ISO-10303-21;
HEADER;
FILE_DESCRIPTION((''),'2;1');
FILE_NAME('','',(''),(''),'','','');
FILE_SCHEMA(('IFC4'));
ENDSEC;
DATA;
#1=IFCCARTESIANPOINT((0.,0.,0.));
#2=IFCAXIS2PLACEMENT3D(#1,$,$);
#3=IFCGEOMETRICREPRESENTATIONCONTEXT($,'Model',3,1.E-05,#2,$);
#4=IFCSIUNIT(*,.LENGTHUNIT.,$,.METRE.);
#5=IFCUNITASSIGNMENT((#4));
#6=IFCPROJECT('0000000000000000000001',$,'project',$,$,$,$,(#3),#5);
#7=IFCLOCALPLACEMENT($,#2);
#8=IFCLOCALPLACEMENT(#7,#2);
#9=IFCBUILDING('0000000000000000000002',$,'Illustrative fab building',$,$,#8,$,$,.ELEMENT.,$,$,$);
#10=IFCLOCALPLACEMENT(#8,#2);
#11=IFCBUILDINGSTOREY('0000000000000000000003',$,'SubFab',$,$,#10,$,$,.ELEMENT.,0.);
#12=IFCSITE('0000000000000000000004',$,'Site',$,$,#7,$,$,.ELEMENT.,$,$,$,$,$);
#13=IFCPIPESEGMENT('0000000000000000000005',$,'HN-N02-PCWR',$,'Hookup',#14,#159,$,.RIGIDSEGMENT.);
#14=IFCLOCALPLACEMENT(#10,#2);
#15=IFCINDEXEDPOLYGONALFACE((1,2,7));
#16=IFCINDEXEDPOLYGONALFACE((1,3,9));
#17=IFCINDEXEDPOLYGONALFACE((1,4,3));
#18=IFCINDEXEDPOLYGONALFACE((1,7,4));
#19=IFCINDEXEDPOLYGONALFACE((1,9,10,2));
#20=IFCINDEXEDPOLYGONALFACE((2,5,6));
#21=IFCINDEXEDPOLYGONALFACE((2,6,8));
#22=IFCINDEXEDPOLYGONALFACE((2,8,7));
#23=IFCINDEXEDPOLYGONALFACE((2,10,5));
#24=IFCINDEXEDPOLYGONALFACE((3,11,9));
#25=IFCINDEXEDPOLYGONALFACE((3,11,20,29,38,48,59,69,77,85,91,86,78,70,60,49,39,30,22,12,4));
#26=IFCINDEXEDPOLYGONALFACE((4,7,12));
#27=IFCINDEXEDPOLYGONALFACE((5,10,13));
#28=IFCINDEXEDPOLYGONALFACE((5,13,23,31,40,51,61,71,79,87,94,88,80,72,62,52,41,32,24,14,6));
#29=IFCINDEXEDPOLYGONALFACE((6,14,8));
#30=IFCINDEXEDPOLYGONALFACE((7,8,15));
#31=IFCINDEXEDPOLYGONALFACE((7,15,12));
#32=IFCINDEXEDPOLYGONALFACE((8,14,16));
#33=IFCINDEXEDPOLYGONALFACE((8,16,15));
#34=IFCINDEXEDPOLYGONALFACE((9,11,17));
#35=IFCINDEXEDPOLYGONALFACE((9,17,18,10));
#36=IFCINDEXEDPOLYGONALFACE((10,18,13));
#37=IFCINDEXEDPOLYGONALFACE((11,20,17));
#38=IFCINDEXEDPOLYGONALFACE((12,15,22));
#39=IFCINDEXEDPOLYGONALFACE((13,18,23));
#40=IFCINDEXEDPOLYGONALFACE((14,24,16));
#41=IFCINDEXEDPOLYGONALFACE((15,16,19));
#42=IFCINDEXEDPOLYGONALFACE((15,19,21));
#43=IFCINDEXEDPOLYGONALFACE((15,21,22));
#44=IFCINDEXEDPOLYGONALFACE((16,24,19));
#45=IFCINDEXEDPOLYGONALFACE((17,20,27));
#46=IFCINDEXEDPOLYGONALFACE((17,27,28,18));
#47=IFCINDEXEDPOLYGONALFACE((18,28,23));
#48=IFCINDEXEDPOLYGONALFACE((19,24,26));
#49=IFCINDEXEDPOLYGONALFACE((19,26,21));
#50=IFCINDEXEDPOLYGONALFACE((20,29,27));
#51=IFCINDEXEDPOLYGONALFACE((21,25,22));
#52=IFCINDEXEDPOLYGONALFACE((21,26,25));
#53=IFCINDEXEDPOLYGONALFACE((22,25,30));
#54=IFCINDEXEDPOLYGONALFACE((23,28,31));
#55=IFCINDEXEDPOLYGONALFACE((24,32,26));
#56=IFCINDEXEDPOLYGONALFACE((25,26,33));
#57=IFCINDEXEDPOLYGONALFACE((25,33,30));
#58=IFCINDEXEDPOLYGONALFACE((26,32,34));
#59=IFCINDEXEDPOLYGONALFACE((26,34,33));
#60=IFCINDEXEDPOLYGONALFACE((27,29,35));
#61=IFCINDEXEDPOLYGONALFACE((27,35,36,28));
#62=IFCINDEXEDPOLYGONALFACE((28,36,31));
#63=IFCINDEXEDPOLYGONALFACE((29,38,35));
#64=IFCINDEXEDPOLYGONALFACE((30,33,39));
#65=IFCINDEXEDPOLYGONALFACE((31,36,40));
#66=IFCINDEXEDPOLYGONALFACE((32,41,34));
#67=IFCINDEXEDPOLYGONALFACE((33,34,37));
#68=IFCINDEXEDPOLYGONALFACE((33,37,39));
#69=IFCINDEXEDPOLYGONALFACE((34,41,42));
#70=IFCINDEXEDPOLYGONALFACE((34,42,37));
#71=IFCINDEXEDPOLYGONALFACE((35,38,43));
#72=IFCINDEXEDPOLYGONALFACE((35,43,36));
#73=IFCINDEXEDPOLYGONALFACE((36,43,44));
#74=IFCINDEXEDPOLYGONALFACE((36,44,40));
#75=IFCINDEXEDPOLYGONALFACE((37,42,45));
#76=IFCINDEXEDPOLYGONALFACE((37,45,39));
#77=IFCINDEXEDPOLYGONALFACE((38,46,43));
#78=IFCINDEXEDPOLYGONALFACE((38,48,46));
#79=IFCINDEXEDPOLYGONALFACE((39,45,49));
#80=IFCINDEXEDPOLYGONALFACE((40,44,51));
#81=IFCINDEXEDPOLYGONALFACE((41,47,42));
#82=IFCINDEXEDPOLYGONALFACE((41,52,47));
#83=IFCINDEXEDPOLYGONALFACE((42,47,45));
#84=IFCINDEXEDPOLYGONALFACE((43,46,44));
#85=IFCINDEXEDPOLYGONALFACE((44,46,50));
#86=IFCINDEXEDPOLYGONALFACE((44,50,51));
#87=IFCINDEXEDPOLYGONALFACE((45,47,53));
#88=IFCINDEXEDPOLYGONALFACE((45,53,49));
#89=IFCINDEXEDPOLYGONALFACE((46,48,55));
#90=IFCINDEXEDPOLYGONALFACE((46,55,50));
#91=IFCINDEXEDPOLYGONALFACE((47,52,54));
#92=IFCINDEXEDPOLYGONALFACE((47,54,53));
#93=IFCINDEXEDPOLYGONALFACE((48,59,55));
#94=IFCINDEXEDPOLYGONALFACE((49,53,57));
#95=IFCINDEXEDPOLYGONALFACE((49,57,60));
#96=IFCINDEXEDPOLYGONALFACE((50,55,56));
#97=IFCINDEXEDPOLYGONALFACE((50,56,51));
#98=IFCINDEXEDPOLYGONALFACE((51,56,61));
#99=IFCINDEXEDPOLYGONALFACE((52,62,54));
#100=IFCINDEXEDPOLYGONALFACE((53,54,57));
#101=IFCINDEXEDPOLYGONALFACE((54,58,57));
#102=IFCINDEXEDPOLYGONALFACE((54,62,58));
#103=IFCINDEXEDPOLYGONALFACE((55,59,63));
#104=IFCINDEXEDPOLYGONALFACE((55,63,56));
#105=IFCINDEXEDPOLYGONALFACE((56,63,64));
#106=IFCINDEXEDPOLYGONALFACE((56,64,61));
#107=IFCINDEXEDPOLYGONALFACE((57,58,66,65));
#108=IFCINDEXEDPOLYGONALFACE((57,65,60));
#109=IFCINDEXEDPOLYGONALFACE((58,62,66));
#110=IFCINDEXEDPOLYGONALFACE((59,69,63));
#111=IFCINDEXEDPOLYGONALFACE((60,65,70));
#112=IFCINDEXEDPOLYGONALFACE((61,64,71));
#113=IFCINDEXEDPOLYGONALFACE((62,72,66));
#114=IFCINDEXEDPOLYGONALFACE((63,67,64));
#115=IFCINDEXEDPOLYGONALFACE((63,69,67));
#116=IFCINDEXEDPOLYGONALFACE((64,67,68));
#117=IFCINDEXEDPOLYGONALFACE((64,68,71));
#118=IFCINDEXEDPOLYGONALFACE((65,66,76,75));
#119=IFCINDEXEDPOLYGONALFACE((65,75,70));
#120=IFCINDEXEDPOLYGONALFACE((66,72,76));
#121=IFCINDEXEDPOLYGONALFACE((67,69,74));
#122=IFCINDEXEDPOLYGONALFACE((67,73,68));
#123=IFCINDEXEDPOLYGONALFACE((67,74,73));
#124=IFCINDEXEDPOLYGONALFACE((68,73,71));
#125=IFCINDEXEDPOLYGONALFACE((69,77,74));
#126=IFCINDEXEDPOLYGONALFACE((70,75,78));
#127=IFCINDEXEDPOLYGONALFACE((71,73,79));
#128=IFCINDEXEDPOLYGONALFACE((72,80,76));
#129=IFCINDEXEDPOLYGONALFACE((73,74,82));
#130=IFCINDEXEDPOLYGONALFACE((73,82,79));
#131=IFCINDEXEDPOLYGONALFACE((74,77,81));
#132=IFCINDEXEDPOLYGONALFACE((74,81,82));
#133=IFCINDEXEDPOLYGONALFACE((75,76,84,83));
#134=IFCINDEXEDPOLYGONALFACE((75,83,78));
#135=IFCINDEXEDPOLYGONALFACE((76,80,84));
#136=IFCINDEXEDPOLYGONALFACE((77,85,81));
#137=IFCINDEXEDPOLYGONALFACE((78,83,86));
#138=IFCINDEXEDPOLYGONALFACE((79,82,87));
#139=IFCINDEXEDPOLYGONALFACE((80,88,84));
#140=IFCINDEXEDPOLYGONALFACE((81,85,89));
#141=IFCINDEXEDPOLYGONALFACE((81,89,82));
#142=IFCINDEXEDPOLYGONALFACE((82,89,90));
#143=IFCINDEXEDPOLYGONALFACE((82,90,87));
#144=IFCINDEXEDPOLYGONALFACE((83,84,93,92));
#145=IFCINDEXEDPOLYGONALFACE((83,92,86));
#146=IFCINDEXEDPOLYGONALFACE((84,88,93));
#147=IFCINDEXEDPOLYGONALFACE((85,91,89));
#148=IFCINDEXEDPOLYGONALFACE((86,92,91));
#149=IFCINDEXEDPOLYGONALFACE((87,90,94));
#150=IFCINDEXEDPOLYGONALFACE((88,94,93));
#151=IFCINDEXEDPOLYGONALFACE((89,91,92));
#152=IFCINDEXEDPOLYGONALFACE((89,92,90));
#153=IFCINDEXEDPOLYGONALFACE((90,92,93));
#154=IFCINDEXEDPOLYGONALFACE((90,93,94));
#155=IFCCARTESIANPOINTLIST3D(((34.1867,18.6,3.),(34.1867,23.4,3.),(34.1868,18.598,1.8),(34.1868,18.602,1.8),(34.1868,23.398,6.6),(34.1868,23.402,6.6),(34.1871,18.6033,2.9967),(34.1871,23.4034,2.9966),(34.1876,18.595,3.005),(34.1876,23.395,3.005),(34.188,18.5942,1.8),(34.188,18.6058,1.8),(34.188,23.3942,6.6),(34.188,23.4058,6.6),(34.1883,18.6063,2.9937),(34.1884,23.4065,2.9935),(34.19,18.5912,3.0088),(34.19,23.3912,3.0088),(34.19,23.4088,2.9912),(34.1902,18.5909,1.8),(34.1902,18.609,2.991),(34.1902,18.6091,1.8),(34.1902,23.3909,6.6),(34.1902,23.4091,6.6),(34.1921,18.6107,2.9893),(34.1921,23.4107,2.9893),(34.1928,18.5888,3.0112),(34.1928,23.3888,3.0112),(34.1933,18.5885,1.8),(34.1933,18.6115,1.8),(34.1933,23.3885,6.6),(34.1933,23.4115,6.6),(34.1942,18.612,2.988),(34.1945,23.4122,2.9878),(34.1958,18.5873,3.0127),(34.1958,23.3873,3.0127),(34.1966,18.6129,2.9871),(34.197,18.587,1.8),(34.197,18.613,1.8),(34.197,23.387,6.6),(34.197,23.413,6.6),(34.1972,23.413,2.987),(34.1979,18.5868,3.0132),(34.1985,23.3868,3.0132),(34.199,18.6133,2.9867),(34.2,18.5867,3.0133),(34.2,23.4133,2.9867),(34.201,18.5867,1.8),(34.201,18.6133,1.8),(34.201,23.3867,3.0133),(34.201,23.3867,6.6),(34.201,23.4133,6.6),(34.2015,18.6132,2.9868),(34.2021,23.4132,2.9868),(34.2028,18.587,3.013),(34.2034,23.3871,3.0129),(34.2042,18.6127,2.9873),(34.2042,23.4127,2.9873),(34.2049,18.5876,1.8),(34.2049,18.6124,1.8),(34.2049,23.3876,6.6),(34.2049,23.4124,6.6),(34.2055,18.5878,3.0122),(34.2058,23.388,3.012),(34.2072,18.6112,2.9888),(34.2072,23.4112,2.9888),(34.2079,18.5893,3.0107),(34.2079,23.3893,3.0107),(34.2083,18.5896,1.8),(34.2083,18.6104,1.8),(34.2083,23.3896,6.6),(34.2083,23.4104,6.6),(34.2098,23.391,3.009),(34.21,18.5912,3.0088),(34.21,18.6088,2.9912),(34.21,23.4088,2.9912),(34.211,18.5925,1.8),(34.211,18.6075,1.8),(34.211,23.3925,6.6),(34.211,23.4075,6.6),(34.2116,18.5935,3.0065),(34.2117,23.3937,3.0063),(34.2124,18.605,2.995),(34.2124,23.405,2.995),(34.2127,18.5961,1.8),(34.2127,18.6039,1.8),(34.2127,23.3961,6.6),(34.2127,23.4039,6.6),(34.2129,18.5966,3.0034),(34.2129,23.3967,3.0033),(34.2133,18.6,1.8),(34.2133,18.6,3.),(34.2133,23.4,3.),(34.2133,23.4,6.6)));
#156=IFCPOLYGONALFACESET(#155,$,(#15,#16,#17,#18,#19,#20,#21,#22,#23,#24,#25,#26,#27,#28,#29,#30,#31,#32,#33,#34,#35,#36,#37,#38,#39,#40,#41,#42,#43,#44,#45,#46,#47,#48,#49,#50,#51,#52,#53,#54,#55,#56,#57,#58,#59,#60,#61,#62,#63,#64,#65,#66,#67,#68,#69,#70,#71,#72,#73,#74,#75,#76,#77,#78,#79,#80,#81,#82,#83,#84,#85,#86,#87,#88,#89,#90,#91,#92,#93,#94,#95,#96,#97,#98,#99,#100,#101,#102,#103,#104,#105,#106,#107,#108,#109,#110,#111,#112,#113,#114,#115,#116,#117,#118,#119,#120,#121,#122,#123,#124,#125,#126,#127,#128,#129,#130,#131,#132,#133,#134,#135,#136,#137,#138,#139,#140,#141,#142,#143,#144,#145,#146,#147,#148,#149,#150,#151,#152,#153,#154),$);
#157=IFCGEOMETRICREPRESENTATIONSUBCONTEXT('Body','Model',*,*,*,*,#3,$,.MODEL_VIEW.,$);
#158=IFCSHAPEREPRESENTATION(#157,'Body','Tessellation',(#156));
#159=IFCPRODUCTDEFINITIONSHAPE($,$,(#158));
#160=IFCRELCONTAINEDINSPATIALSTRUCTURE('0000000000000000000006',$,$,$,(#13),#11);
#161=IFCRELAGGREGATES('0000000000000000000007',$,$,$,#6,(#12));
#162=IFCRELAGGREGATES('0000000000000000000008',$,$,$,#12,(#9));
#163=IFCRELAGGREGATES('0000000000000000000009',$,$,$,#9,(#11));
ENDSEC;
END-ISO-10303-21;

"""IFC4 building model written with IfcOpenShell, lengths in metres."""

from ifc_helpers import new_model, entity, si_unit, origin, place, context, subcontext, project, spatial, element, save


model = new_model("IFC4")

# Units and contexts
model_context = context("Model", 3, precision=1e-05, world=origin())
body_context = subcontext(model_context, "Body", "Model", "MODEL_VIEW")
ifc_project = project(units=[si_unit("LENGTHUNIT", "METRE")], contexts=[model_context])

# Site, building, storey
site_placement = place(None, origin())
site = spatial("IfcSite", under=ifc_project, at=site_placement, Name="Site", CompositionType="ELEMENT")
building_placement = place(site_placement, origin())
building = spatial("IfcBuilding", under=site, at=building_placement, Name="Illustrative fab building", CompositionType="ELEMENT")
storey_placement = place(building_placement, origin())
storey = spatial("IfcBuildingStorey", under=building, at=storey_placement, Name="SubFab", CompositionType="ELEMENT", Elevation=0.0)

# Pipe segment
pipe_segment_1_placement = place(storey_placement, origin())
element("IfcPipeSegment", 1, at=pipe_segment_1_placement, inside=storey, Name="HN-N02-PCWR", ObjectType="Hookup", PredefinedType="RIGIDSEGMENT", context=body_context, shape_type="AdvancedSweptSolid", body=[
    entity("IfcSweptDiskSolid", entity("IfcPolyline", [entity("IfcCartesianPoint", [34.2, 18.6, 1.8]), entity("IfcCartesianPoint", [34.2, 18.6, 3.0]), entity("IfcCartesianPoint", [34.2, 23.4, 3.0]), entity("IfcCartesianPoint", [34.2, 23.4, 6.6])]), 0.0133),
])

save(model, "model.ifc")
